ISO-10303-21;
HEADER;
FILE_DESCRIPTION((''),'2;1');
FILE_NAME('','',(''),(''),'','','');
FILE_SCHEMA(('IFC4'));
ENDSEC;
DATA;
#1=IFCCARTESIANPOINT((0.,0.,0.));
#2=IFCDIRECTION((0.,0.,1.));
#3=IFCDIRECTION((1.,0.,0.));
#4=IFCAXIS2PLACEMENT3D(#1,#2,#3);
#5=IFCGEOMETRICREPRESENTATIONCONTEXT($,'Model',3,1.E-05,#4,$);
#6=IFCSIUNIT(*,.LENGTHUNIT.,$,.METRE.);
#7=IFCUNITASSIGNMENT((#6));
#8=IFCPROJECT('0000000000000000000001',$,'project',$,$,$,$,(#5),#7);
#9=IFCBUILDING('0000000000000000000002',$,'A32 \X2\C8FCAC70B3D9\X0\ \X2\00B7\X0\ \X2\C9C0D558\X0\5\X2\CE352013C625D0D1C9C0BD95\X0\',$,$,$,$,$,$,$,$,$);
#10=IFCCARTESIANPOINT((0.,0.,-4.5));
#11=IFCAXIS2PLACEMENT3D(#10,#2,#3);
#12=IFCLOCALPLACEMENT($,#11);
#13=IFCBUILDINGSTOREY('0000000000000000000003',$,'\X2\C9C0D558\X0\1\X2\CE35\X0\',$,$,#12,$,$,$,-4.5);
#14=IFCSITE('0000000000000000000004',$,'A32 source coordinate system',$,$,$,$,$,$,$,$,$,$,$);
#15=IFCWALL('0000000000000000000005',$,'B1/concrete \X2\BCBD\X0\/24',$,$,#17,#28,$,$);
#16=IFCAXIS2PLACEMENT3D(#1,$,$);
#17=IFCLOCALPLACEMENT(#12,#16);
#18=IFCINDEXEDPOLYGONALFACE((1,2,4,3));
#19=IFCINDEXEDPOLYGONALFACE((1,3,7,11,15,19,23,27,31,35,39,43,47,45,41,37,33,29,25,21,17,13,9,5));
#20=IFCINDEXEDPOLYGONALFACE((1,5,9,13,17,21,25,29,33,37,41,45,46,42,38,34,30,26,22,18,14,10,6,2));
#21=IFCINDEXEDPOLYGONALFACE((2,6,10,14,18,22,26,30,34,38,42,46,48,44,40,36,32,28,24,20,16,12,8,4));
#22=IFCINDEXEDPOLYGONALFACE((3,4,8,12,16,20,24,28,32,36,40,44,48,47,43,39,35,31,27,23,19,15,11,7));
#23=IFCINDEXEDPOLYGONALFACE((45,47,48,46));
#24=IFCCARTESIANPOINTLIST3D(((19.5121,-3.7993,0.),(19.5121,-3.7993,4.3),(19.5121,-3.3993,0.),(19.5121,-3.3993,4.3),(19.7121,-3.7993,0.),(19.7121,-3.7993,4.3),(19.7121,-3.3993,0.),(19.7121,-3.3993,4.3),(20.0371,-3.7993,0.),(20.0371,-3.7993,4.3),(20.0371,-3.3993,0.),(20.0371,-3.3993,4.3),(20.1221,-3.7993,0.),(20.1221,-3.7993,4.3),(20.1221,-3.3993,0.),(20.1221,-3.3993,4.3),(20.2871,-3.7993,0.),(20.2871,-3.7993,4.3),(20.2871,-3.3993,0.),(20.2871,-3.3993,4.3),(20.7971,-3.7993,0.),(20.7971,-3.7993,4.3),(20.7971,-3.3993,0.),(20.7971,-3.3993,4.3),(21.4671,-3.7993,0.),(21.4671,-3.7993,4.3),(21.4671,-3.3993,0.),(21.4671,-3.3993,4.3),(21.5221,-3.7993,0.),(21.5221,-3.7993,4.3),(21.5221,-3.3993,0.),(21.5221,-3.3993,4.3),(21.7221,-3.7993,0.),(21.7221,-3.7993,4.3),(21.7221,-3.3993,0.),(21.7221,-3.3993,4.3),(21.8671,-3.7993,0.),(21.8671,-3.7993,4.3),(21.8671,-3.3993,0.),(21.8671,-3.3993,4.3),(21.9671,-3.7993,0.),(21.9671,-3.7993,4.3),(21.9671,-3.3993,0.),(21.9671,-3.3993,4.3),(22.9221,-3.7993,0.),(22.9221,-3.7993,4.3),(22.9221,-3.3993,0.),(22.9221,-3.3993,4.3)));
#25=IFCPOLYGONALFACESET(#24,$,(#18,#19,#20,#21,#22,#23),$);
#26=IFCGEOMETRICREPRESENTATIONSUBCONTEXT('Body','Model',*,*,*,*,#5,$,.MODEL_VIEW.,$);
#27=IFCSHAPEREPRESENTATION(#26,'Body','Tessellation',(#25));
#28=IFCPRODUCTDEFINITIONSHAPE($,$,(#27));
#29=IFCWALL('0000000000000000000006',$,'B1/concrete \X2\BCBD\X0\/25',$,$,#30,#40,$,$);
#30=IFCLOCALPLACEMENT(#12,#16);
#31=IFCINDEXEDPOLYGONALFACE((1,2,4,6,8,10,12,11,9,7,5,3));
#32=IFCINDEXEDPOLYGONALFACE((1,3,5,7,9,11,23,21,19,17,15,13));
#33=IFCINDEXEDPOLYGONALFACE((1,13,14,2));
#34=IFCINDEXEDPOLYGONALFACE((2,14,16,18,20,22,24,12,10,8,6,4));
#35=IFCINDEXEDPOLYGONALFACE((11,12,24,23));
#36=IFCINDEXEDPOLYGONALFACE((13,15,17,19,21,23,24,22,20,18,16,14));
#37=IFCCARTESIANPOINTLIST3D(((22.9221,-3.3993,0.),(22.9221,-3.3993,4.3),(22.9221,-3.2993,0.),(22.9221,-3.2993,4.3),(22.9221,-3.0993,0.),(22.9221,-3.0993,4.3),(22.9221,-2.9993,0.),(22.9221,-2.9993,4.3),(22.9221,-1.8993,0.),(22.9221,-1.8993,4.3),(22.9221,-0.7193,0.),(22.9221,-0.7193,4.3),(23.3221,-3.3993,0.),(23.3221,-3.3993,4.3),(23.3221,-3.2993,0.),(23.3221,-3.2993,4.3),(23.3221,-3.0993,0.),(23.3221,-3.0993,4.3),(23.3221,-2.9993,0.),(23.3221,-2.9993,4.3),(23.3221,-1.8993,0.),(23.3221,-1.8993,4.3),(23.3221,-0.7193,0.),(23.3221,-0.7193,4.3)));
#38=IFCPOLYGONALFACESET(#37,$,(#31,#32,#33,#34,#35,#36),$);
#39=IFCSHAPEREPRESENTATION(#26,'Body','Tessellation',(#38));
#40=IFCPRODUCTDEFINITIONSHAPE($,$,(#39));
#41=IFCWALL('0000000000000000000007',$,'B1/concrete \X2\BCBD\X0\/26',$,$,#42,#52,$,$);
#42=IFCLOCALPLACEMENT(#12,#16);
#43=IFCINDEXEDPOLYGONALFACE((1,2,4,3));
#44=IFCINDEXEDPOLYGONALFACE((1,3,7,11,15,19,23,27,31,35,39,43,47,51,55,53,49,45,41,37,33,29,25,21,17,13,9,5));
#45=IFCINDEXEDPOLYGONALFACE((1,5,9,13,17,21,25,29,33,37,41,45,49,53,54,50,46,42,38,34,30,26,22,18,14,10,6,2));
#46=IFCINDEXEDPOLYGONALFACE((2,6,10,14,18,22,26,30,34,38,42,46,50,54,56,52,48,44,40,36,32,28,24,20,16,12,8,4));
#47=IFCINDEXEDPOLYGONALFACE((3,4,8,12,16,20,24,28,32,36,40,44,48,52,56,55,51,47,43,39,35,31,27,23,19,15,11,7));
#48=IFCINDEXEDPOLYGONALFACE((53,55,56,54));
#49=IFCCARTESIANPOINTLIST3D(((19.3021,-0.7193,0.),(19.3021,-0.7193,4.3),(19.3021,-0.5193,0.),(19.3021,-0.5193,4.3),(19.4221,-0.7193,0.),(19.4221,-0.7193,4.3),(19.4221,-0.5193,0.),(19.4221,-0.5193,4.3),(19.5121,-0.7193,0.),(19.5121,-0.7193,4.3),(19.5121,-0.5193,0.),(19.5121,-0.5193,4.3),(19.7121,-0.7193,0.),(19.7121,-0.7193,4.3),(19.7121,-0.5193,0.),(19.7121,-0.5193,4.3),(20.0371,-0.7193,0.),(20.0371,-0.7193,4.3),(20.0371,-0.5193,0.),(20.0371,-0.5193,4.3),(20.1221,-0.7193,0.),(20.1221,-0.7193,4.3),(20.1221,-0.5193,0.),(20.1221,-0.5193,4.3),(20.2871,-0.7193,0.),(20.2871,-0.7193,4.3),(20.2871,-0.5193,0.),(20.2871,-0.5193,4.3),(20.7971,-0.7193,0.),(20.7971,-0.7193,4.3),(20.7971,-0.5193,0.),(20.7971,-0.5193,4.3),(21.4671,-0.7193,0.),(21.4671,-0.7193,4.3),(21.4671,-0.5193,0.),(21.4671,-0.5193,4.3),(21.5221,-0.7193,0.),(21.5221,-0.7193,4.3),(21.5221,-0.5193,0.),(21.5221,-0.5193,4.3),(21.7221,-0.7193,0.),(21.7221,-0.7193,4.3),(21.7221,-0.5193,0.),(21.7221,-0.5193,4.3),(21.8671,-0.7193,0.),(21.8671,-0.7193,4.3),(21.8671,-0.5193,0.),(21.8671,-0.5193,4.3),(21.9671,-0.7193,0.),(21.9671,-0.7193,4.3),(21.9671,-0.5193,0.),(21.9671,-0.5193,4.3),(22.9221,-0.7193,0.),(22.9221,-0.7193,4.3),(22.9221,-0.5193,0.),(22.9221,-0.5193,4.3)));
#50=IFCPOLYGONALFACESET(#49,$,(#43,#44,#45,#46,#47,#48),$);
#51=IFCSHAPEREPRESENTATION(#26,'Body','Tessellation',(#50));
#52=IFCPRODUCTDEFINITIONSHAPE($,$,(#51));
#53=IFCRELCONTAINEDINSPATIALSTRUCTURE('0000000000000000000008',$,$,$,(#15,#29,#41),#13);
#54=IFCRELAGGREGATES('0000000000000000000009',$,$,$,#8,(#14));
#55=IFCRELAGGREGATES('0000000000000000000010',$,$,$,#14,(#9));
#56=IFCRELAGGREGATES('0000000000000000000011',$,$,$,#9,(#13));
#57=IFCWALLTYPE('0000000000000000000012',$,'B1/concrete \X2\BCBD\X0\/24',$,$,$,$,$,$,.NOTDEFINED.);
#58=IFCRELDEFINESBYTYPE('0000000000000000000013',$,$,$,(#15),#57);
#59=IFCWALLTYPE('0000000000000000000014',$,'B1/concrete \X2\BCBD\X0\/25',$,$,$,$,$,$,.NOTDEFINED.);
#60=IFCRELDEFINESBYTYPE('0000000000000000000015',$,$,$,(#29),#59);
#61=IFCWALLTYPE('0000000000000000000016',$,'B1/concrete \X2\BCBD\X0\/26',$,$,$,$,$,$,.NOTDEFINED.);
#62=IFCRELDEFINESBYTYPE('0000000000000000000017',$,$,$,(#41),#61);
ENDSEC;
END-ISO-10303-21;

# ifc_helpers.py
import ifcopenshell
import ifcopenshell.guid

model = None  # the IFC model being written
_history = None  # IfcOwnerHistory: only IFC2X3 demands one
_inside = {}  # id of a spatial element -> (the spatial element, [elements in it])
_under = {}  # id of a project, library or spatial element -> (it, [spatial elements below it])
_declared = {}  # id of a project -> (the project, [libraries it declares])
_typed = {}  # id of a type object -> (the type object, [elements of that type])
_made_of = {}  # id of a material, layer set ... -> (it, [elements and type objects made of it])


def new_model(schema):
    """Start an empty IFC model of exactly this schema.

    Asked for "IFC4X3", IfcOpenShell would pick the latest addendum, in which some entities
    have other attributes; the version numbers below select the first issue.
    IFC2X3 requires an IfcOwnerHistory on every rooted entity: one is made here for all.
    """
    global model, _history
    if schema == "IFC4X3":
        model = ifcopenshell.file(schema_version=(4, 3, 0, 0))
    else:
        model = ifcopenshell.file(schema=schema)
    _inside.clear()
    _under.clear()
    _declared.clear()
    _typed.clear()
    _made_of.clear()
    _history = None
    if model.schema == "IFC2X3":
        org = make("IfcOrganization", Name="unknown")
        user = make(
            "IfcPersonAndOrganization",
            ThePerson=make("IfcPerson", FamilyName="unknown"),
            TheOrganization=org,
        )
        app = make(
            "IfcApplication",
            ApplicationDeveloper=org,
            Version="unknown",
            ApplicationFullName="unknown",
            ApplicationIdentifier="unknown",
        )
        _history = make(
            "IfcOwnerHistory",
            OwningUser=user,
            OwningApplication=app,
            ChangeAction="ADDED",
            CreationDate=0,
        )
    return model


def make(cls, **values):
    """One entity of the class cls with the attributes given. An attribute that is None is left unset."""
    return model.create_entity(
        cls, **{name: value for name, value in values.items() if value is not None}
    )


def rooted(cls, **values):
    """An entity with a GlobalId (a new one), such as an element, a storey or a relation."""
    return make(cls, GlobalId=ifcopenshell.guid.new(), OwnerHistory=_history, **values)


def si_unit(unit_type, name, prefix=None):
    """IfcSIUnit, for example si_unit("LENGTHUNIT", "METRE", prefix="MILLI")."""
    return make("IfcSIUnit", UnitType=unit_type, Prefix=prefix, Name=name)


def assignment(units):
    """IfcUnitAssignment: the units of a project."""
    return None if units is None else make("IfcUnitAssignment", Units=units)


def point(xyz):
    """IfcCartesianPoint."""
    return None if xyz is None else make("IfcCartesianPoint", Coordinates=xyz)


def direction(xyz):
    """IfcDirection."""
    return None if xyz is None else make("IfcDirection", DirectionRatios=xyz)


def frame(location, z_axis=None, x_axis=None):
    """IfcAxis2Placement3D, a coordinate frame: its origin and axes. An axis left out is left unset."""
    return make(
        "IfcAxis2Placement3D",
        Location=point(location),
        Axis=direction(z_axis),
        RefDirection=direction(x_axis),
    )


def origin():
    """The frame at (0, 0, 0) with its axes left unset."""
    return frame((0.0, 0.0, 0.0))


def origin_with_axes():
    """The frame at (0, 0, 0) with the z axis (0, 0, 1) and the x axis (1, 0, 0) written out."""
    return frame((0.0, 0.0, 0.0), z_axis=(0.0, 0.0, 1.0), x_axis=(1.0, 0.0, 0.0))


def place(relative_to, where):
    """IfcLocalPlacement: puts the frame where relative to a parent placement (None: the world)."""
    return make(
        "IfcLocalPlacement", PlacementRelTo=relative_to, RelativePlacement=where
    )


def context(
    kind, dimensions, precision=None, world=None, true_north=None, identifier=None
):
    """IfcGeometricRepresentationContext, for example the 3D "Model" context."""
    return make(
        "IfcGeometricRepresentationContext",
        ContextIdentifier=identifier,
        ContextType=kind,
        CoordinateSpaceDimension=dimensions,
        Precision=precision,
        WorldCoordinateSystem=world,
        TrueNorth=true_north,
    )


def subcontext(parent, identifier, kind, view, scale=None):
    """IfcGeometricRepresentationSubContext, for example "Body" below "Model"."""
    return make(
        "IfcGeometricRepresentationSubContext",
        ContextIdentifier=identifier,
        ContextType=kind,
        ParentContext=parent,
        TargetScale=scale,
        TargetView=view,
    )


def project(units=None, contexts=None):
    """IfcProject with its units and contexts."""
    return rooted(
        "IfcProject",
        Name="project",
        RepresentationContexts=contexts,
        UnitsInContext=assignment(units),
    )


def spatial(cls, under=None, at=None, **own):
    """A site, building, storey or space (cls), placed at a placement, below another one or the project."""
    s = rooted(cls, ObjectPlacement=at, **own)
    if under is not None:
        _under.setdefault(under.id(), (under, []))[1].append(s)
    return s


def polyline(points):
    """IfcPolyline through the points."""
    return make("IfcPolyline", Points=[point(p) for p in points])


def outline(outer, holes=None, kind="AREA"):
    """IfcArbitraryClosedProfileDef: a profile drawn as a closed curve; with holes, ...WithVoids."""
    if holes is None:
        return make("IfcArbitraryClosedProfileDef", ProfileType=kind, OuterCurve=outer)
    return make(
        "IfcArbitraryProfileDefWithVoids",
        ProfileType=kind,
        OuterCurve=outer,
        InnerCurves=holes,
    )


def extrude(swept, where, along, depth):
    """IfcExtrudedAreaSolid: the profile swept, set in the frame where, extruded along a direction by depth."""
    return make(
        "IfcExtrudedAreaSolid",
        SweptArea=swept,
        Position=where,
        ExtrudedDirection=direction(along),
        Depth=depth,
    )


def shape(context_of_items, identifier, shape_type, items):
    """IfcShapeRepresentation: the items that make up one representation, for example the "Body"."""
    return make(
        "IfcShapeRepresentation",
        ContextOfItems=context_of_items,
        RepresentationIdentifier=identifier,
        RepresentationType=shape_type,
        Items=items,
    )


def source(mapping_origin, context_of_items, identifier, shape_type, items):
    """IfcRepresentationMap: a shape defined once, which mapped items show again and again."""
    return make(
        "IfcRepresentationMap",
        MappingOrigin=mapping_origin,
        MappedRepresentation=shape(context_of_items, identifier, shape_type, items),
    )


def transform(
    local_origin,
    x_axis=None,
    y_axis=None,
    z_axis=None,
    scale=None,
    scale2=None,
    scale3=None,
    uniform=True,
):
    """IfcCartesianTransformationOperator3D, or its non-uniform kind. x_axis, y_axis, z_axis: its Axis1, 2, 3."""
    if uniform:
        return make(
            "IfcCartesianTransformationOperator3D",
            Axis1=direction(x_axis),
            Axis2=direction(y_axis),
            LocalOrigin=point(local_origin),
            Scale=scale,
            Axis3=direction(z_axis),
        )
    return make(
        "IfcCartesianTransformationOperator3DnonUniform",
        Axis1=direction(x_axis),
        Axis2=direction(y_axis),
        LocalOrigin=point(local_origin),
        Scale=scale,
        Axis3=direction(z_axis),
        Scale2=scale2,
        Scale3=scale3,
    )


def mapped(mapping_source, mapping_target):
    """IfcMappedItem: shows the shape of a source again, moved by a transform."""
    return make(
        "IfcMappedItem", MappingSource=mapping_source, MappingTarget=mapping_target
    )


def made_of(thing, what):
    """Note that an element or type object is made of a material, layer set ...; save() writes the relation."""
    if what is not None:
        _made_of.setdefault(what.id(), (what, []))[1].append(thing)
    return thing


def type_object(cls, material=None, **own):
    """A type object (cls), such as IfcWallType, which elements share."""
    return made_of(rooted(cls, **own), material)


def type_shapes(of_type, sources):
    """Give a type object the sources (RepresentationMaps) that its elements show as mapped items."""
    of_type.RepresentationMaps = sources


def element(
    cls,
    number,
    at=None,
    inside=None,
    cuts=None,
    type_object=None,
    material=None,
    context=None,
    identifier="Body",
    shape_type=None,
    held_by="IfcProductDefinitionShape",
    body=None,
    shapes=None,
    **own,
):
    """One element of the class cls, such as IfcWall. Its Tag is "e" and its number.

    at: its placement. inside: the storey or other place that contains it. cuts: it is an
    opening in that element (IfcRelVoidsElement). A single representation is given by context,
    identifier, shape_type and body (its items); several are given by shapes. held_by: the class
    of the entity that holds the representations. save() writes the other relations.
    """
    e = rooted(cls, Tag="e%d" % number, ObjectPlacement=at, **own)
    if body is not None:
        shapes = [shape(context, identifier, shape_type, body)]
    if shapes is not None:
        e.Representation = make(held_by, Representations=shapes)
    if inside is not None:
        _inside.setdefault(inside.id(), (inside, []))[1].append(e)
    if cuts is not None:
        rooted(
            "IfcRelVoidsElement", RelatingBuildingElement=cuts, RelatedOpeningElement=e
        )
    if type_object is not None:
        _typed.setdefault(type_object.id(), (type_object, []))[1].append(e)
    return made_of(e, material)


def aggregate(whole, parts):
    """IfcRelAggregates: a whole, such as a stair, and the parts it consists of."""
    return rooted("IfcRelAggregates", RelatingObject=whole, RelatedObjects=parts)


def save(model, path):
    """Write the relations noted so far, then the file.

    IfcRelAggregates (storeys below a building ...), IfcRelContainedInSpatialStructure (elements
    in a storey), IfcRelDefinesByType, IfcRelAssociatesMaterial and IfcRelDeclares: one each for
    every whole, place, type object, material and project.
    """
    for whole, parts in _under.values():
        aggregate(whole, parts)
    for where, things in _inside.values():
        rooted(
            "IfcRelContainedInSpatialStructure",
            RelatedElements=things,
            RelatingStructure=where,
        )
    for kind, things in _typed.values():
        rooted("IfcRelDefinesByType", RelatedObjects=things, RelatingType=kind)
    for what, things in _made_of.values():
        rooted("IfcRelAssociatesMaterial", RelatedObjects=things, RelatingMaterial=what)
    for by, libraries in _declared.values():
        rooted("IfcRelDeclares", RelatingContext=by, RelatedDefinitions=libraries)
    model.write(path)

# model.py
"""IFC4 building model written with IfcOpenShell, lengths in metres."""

from ifc_helpers import new_model, si_unit, frame, origin, origin_with_axes, place, context, subcontext, project, spatial, polyline, outline, extrude, source, transform, mapped, type_object, type_shapes, element, save


model = new_model("IFC4")

# Units and contexts
model_context = context("Model", 3, precision=1e-05, world=origin_with_axes())
body_context = subcontext(model_context, "Body", "Model", "MODEL_VIEW")
ifc_project = project(units=[si_unit("LENGTHUNIT", "METRE")], contexts=[model_context])

# Site, building, storey
site = spatial("IfcSite", under=ifc_project, Name="A32 source coordinate system")
building = spatial("IfcBuilding", under=site, Name="A32 주거동 · 지하5층–옥탑지붕")
storey_placement = place(None, frame((0.0, 0.0, -4.5), z_axis=(0.0, 0.0, 1.0), x_axis=(1.0, 0.0, 0.0)))
storey = spatial("IfcBuildingStorey", under=building, at=storey_placement, Name="지하1층", Elevation=-4.5)

# Walls
wall_type_1 = type_object("IfcWallType", Name="B1/concrete 벽/24", PredefinedType="NOTDEFINED")
shared_shape_1 = source(origin(), body_context, "Body", "SweptSolid", [
    extrude(outline(polyline([(20.1221, -3.3993), (20.2871, -3.3993), (20.7971, -3.3993), (21.4671, -3.3993), (21.5221, -3.3993), (21.7221, -3.3993), (21.8671, -3.3993), (21.9671, -3.3993), (22.9221, -3.3993), (22.9221, -3.7993), (21.9671, -3.7993), (21.8671, -3.7993), (21.7221, -3.7993), (21.5221, -3.7993), (21.4671, -3.7993), (20.7971, -3.7993), (20.2871, -3.7993), (20.1221, -3.7993), (20.0371, -3.7993), (19.7121, -3.7993), (19.5121, -3.7993), (19.5121, -3.3993), (19.7121, -3.3993), (20.0371, -3.3993), (20.1221, -3.3993)])), origin(), (0.0, 0.0, 1.0), 4.3),
])
type_shapes(wall_type_1, [shared_shape_1])
wall_1_placement = place(storey_placement, origin_with_axes())
element("IfcWall", 1, at=wall_1_placement, inside=storey, type_object=wall_type_1, Name="B1/concrete 벽/24", context=body_context, shape_type="MappedRepresentation", body=[
    mapped(shared_shape_1, transform((0.0, 0.0, 0.0), scale=1.0)),
])
wall_type_2 = type_object("IfcWallType", Name="B1/concrete 벽/25", PredefinedType="NOTDEFINED")
shared_shape_2 = source(origin(), body_context, "Body", "SweptSolid", [
    extrude(outline(polyline([(22.9221, -2.9993), (22.9221, -1.8993), (22.9221, -0.7193), (23.3221, -0.7193), (23.3221, -1.8993), (23.3221, -2.9993), (23.3221, -3.0993), (23.3221, -3.2993), (23.3221, -3.3993), (22.9221, -3.3993), (22.9221, -3.2993), (22.9221, -3.0993), (22.9221, -2.9993)])), origin(), (0.0, 0.0, 1.0), 4.3),
])
type_shapes(wall_type_2, [shared_shape_2])
wall_2_placement = place(storey_placement, origin_with_axes())
element("IfcWall", 2, at=wall_2_placement, inside=storey, type_object=wall_type_2, Name="B1/concrete 벽/25", context=body_context, shape_type="MappedRepresentation", body=[
    mapped(shared_shape_2, transform((0.0, 0.0, 0.0), scale=1.0)),
])
wall_type_3 = type_object("IfcWallType", Name="B1/concrete 벽/26", PredefinedType="NOTDEFINED")
shared_shape_3 = source(origin(), body_context, "Body", "SweptSolid", [
    extrude(outline(polyline([(21.7221, -0.7193), (21.5221, -0.7193), (21.4671, -0.7193), (20.7971, -0.7193), (20.2871, -0.7193), (20.1221, -0.7193), (20.0371, -0.7193), (19.7121, -0.7193), (19.5121, -0.7193), (19.4221, -0.7193), (19.3021, -0.7193), (19.3021, -0.5193), (19.4221, -0.5193), (19.5121, -0.5193), (19.7121, -0.5193), (20.0371, -0.5193), (20.1221, -0.5193), (20.2871, -0.5193), (20.7971, -0.5193), (21.4671, -0.5193), (21.5221, -0.5193), (21.7221, -0.5193), (21.8671, -0.5193), (21.9671, -0.5193), (22.9221, -0.5193), (22.9221, -0.7193), (21.9671, -0.7193), (21.8671, -0.7193), (21.7221, -0.7193)])), origin(), (0.0, 0.0, 1.0), 4.3),
])
type_shapes(wall_type_3, [shared_shape_3])
wall_3_placement = place(storey_placement, origin_with_axes())
element("IfcWall", 3, at=wall_3_placement, inside=storey, type_object=wall_type_3, Name="B1/concrete 벽/26", context=body_context, shape_type="MappedRepresentation", body=[
    mapped(shared_shape_3, transform((0.0, 0.0, 0.0), scale=1.0)),
])

save(model, "model.ifc")
